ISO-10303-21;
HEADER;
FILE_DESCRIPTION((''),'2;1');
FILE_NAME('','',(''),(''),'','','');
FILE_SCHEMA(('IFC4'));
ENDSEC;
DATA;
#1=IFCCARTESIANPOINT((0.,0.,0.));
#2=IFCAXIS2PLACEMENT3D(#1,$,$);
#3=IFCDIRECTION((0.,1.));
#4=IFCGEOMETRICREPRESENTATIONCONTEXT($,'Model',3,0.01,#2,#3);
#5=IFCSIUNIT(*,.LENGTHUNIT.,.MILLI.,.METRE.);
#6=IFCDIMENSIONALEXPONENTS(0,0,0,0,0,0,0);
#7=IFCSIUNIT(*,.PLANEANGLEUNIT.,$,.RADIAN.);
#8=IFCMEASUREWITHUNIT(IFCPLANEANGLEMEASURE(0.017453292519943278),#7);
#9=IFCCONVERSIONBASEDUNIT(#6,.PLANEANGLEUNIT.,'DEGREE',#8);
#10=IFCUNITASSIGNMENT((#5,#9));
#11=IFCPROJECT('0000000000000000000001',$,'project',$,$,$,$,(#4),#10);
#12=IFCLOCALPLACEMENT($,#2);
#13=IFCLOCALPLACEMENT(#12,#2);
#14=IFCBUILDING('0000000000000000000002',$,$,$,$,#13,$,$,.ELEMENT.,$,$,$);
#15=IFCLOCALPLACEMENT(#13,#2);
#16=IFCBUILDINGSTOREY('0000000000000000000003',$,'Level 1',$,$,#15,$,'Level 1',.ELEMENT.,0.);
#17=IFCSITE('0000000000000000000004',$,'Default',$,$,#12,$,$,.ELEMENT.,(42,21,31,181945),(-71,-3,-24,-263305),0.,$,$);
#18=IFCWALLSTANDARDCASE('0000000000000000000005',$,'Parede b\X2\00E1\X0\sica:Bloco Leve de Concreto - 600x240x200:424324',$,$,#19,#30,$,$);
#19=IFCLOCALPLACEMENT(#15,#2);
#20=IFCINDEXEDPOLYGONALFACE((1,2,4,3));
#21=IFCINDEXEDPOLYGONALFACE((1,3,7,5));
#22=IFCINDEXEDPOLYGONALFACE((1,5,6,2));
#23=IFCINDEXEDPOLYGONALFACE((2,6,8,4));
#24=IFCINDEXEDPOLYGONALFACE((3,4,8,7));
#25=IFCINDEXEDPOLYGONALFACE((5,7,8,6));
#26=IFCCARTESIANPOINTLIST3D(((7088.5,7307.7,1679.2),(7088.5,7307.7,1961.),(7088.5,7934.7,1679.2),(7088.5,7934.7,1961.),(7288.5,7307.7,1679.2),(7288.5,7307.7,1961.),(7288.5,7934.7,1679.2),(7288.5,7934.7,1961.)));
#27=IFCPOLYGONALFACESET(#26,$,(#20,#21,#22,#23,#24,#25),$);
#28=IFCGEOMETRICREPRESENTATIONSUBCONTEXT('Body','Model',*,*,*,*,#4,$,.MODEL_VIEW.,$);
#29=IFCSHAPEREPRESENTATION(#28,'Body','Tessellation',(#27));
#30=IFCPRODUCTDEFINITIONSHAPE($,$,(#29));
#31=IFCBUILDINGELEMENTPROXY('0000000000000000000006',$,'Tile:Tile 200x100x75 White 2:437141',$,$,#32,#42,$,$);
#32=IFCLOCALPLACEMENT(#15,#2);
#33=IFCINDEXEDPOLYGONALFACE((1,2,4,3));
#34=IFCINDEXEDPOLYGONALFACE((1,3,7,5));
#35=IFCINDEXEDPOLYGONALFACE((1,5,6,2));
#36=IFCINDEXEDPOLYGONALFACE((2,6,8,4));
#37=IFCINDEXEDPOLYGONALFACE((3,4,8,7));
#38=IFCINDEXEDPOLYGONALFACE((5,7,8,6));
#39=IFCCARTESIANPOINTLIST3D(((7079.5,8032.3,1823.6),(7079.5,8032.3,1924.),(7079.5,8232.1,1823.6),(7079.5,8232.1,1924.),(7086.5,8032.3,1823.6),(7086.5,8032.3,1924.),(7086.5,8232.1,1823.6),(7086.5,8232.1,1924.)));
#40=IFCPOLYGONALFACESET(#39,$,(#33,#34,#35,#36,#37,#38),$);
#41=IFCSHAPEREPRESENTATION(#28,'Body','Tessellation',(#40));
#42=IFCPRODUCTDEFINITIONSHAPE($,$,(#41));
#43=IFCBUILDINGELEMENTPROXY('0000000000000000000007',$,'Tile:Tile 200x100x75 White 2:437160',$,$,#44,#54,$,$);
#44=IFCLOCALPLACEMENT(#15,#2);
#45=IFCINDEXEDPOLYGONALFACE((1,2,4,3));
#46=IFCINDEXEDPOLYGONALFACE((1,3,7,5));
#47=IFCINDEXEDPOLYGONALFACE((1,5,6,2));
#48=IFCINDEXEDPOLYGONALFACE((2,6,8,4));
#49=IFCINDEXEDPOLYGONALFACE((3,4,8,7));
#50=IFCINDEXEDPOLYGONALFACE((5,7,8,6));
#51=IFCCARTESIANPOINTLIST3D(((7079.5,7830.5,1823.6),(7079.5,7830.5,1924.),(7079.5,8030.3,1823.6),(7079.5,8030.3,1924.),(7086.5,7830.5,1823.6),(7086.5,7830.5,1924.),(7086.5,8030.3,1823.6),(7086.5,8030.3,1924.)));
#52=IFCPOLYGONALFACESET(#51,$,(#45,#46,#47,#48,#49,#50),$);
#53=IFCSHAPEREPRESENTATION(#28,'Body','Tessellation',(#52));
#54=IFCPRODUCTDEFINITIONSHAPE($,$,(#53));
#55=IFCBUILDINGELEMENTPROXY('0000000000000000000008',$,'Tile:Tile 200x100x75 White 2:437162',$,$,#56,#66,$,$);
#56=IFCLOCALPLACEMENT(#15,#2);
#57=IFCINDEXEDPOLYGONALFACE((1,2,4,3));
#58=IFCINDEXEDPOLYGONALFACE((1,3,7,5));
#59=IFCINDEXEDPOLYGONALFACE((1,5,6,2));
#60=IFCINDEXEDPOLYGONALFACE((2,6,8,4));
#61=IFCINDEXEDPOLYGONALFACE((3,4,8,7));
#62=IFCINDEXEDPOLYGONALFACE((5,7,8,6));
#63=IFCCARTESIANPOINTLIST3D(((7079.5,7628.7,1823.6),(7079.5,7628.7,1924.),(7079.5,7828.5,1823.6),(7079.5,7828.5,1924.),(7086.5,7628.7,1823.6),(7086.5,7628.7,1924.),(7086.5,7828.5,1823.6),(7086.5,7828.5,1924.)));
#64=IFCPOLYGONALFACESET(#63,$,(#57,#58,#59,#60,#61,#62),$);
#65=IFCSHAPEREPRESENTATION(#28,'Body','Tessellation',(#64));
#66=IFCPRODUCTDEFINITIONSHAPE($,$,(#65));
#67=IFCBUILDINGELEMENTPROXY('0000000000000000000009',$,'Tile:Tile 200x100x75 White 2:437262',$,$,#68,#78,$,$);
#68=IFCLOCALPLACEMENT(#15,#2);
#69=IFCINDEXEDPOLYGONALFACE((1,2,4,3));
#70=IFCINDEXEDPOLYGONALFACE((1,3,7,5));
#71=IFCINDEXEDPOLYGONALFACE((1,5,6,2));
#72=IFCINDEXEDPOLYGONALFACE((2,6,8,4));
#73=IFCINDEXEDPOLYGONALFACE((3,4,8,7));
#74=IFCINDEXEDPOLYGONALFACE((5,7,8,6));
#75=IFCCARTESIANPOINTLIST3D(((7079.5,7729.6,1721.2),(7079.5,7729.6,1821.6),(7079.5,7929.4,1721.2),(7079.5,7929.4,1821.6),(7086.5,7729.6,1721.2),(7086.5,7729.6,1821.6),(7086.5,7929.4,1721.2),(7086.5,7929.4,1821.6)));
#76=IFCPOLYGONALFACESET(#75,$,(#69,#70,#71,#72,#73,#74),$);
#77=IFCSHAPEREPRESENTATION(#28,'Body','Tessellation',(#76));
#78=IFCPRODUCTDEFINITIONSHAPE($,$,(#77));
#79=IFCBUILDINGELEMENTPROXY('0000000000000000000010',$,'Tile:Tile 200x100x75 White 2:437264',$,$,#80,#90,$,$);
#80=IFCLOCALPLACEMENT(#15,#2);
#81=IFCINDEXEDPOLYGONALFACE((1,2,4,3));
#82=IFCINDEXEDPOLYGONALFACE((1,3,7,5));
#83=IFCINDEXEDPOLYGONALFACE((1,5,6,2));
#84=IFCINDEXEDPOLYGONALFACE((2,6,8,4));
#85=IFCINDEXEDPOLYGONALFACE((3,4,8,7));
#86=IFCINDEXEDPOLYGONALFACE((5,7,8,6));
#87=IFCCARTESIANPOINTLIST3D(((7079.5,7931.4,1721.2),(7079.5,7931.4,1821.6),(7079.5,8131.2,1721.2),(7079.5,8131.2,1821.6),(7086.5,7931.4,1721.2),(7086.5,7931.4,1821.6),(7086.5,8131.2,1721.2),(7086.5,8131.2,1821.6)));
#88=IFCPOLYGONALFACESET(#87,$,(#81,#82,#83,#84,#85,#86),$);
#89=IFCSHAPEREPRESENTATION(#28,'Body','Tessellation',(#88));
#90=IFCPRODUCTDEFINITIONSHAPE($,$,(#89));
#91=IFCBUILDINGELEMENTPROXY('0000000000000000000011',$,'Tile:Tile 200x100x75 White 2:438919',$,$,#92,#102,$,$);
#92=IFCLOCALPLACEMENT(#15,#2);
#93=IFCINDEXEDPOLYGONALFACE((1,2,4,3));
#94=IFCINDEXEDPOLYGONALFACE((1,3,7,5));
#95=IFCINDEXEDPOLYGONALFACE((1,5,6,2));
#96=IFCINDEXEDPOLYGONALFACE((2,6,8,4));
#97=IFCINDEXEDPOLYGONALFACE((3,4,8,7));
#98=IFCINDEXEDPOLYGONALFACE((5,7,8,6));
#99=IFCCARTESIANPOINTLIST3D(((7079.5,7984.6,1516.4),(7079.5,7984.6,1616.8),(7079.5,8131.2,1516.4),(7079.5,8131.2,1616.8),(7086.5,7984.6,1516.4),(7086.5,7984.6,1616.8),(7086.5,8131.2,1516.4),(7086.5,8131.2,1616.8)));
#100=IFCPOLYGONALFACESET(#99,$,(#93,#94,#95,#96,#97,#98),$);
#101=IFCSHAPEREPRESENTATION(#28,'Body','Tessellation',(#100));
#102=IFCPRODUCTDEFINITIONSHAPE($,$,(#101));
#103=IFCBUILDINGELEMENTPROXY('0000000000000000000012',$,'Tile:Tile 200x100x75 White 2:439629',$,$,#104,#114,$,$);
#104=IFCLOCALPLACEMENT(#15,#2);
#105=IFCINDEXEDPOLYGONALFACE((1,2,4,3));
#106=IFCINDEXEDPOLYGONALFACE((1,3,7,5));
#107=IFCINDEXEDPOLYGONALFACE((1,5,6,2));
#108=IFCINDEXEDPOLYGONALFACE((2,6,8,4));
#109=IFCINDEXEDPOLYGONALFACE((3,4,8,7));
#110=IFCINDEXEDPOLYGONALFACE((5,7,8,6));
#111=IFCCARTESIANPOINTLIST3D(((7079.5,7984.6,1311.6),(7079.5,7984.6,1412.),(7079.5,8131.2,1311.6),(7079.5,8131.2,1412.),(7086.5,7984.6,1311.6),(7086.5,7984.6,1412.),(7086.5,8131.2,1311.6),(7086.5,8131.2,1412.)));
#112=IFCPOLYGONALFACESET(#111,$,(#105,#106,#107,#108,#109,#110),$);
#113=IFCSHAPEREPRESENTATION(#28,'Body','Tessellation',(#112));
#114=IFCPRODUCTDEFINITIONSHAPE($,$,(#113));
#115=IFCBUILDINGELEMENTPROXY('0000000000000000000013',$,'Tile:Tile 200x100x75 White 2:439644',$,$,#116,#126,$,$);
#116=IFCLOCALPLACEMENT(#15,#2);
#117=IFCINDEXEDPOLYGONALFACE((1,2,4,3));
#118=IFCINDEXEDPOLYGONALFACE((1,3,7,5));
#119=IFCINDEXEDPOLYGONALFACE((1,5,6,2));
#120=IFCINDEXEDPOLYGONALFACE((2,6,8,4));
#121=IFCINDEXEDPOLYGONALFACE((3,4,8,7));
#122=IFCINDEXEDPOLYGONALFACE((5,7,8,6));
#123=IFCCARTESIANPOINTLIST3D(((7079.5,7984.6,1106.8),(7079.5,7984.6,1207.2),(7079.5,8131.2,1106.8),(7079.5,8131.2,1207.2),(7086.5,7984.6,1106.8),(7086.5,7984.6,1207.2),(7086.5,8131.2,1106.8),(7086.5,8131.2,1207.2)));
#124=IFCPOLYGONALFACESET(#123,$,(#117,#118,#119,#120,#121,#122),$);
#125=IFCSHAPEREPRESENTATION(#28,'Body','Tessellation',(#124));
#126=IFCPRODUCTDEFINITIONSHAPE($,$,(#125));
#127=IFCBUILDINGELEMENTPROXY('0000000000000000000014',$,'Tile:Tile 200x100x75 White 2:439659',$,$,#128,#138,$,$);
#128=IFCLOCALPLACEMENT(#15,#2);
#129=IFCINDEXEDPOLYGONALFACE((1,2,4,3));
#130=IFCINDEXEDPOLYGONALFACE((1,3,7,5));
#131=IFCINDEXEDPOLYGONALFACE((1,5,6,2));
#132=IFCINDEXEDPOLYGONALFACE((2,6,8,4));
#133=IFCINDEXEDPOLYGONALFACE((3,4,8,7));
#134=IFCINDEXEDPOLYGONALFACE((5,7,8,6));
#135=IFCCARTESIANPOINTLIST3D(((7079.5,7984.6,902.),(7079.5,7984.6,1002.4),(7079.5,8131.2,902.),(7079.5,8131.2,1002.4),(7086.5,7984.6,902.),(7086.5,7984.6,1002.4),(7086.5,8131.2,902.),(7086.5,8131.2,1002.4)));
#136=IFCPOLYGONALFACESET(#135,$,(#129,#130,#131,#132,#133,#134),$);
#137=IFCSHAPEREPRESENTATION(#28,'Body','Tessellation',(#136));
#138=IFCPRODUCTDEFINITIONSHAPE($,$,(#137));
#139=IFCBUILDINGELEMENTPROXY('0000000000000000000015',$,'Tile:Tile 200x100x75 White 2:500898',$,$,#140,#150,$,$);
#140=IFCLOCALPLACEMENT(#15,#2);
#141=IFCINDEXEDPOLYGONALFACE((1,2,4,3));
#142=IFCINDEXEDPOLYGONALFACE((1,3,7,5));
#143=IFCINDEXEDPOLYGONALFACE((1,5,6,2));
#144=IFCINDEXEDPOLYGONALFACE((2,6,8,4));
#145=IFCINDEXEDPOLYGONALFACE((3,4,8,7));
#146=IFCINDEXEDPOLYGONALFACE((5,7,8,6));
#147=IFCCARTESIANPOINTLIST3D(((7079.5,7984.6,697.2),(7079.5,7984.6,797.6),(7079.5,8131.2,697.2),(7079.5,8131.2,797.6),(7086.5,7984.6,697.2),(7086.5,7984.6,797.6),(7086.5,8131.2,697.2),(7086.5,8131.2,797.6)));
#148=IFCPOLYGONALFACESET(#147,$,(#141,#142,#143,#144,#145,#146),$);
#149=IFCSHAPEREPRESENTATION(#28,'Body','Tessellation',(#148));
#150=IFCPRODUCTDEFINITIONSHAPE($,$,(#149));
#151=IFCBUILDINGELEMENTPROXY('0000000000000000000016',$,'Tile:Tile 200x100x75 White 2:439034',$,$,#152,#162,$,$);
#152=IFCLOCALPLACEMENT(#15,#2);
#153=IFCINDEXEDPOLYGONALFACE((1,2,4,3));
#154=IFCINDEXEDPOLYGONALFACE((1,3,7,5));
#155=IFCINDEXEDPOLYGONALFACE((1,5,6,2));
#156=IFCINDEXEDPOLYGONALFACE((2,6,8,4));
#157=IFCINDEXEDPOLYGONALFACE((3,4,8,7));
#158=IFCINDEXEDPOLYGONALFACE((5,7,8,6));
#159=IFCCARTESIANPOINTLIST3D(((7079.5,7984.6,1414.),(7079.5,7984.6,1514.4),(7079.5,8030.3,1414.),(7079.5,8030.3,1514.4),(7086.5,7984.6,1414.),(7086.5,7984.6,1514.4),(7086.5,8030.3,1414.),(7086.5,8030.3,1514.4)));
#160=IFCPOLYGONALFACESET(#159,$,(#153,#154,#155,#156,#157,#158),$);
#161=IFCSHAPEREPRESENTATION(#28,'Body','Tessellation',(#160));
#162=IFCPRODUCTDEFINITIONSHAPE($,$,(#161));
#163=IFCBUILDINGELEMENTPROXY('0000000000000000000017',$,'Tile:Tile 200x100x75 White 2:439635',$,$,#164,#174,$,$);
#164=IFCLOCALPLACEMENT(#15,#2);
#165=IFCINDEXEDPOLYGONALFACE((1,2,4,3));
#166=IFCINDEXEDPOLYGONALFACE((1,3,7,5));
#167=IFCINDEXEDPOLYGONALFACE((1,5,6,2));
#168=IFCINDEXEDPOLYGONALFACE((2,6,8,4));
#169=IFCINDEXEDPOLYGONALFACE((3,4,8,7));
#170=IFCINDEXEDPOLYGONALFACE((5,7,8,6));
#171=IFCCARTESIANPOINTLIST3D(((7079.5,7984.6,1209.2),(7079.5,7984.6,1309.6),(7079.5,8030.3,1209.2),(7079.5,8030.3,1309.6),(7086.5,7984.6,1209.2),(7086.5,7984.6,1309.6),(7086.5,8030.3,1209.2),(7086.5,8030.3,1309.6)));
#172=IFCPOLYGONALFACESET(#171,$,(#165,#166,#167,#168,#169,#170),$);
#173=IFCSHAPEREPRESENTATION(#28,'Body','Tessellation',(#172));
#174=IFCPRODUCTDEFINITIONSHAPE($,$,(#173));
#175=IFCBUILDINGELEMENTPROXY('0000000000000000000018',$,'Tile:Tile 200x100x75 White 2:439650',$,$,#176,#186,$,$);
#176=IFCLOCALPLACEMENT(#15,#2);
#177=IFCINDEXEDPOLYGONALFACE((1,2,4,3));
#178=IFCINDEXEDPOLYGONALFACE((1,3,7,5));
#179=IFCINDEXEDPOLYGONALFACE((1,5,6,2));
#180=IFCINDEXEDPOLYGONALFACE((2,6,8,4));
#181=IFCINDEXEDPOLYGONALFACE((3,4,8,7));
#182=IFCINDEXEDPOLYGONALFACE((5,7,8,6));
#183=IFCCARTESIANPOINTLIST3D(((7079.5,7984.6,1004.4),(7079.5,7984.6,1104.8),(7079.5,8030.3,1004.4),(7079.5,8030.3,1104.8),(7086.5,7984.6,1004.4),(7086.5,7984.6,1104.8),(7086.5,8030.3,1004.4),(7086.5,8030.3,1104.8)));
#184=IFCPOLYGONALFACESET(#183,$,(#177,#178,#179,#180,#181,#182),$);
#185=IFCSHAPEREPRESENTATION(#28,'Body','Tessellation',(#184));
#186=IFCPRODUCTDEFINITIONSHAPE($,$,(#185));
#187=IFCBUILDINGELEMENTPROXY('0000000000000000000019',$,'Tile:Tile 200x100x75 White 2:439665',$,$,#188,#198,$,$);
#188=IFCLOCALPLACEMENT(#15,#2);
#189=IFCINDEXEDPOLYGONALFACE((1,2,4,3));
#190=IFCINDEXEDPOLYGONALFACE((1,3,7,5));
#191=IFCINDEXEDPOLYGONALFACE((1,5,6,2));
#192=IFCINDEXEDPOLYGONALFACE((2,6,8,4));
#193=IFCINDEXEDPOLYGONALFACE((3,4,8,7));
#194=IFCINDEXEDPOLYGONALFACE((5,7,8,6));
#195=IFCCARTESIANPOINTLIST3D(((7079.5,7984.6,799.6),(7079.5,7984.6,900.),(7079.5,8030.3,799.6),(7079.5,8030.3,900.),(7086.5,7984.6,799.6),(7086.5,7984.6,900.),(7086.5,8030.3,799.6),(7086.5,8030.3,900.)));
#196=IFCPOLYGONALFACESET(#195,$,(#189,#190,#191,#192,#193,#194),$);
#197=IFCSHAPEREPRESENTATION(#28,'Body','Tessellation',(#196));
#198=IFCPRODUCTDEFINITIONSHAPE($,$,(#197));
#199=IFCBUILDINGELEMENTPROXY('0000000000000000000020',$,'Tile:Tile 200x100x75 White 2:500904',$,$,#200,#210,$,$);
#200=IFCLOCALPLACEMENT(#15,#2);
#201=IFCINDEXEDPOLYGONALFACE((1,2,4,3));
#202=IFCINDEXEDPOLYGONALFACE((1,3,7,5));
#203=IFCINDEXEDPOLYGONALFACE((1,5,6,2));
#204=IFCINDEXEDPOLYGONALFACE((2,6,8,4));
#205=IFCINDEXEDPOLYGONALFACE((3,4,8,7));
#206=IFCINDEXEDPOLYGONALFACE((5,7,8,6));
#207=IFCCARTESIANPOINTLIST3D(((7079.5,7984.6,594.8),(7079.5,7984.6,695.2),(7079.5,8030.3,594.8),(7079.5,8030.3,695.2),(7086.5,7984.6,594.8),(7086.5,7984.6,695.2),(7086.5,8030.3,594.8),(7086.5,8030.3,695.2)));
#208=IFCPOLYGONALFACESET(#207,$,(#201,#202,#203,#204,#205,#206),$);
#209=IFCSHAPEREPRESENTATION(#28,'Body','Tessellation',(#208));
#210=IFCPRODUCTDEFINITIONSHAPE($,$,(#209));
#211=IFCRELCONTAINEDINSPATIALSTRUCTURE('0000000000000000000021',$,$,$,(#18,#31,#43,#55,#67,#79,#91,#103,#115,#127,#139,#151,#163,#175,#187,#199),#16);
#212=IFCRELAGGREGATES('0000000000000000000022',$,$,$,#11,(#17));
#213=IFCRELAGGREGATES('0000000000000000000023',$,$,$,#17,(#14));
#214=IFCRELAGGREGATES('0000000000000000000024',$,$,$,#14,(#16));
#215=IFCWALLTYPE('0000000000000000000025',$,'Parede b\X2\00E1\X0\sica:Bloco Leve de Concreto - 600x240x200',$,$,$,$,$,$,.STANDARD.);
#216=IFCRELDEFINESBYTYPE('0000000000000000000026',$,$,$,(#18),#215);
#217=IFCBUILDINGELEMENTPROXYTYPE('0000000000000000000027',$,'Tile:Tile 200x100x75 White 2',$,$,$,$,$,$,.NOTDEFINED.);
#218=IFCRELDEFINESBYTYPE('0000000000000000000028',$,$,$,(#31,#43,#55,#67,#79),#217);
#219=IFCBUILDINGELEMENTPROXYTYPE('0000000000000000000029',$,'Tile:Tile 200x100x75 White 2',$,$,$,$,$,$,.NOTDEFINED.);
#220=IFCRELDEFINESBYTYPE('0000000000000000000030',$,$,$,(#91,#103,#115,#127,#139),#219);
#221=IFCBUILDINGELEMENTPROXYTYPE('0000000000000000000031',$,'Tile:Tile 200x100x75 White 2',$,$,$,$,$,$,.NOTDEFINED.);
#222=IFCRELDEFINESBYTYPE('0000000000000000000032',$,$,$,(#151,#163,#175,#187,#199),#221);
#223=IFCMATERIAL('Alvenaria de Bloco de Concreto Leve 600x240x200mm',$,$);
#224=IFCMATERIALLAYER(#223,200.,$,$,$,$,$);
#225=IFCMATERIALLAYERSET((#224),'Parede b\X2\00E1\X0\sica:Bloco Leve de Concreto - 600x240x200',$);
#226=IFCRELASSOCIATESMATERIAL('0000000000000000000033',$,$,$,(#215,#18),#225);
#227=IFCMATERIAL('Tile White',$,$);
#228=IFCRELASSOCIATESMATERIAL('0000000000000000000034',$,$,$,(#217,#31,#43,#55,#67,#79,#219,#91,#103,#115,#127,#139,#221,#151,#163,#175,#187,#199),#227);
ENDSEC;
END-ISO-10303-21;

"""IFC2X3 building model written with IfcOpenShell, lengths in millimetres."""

from ifc_helpers import new_model, entity, si_unit, converted_unit, direction, frame, frame_2d, origin, origin_2d_with_axis, place, context, subcontext, project, spatial, rectangle, extrude, source, transform, mapped, material, layer, layer_set, layer_usage, type_object, type_shapes, element, save


model = new_model("IFC2X3")

# Units and contexts
model_context = context("Model", 3, precision=0.01, world=origin(), true_north=direction((0.0, 1.0)))
body_context = subcontext(model_context, "Body", "Model", "MODEL_VIEW")
ifc_project = project(units=[si_unit("LENGTHUNIT", "METRE", prefix="MILLI"), converted_unit("PLANEANGLEUNIT", "DEGREE", entity("IfcPlaneAngleMeasure", 0.017453292519943278), si_unit("PLANEANGLEUNIT", "RADIAN"), dimensions=[0, 0, 0, 0, 0, 0, 0])], contexts=[model_context])

# Site, building, storey
site_placement = place(None, origin())
site = spatial("IfcSite", under=ifc_project, at=site_placement, Name="Default", CompositionType="ELEMENT", RefLatitude=(42, 21, 31, 181945), RefLongitude=(-71, -3, -24, -263305), RefElevation=0.0)
building_placement = place(site_placement, origin())
building = spatial("IfcBuilding", under=site, at=building_placement, CompositionType="ELEMENT")
storey_placement = place(building_placement, origin())
storey = spatial("IfcBuildingStorey", under=building, at=storey_placement, Name="Level 1", LongName="Level 1", CompositionType="ELEMENT", Elevation=0.0)

# Wall
ifc_material_1 = material(Name="Alvenaria de Bloco de Concreto Leve 600x240x200mm")
ifc_layer = layer(ifc_material_1, 200.0)
ifc_layer_set = layer_set([ifc_layer], Name="Parede básica:Bloco Leve de Concreto - 600x240x200")
ifc_layer_usage = layer_usage(ifc_layer_set, "AXIS2", "NEGATIVE", 100.0)
wall_type = type_object("IfcWallType", Name="Parede básica:Bloco Leve de Concreto - 600x240x200", PredefinedType="STANDARD", material=ifc_layer_set)
wall_placement = place(storey_placement, frame((7188.5, 7934.7, 1679.2), z_axis=(0.0, 0.0, 1.0), x_axis=(0.0, -1.0, 0.0)))
element("IfcWallStandardCase", 1, at=wall_placement, inside=storey, type_object=wall_type, material=ifc_layer_usage, Name="Parede básica:Bloco Leve de Concreto - 600x240x200:424324", context=body_context, shape_type="SweptSolid", body=[
    extrude(rectangle(XDim=627.0, YDim=200.0, at=frame_2d((313.5, 0.0), x_axis=(-1.0, 0.0))), origin(), (0.0, 0.0, 1.0), 281.8),
])

# Building element proxies
ifc_material_2 = material(Name="Tile White")
building_element_proxy_type_1 = type_object("IfcBuildingElementProxyType", Name="Tile:Tile 200x100x75 White 2", PredefinedType="NOTDEFINED", material=ifc_material_2)
shared_shape_1 = source(origin(), body_context, "Body", "SweptSolid", [
    extrude(rectangle(XDim=199.8, YDim=100.4, at=frame_2d((0.0, 0.0), x_axis=(1.0, 0.0))), frame((-50.2, -99.9, 0.0), z_axis=(0.0, 0.0, 1.0), x_axis=(0.0, -1.0, 0.0)), (0.0, 0.0, 1.0), 7.0),
])
type_shapes(building_element_proxy_type_1, [shared_shape_1])
for number, where, z_axis, x_axis, name in (
    (2, (7086.5, 8232.1, 1924.0), (-1.0, 0.0, 0.0), (0.0, 0.0, 1.0), "Tile:Tile 200x100x75 White 2:437141"),
    (3, (7086.5, 8030.3, 1924.0), (-1.0, 0.0, 0.0), (0.0, 0.0, 1.0), "Tile:Tile 200x100x75 White 2:437160"),
    (4, (7086.5, 7828.5, 1924.0), (-1.0, 0.0, 0.0), (0.0, 0.0, 1.0), "Tile:Tile 200x100x75 White 2:437162"),
    (5, (7086.5, 7929.4, 1821.6), (-1.0, 0.0, 0.0), (0.0, 0.0, 1.0), "Tile:Tile 200x100x75 White 2:437262"),
    (6, (7086.5, 8131.2, 1821.6), (-1.0, 0.0, 0.0), (0.0, 0.0, 1.0), "Tile:Tile 200x100x75 White 2:437264"),
):
    element("IfcBuildingElementProxy", number, at=place(storey_placement, frame(where, z_axis=z_axis, x_axis=x_axis)), inside=storey, type_object=building_element_proxy_type_1, material=ifc_material_2, Name=name, context=body_context, shape_type="MappedRepresentation", body=[
        mapped(shared_shape_1, transform((0.0, 0.0, 0.0), scale=1.0)),
    ])
building_element_proxy_type_2 = type_object("IfcBuildingElementProxyType", Name="Tile:Tile 200x100x75 White 2", PredefinedType="NOTDEFINED", material=ifc_material_2)
shared_shape_2 = source(origin(), body_context, "Body", "SweptSolid", [
    extrude(rectangle(XDim=146.6, YDim=100.4, at=origin_2d_with_axis()), frame((-50.2, -73.3, 0.0), z_axis=(0.0, 0.0, 1.0), x_axis=(0.0, -1.0, 0.0)), (0.0, 0.0, 1.0), 7.0),
])
type_shapes(building_element_proxy_type_2, [shared_shape_2])
for number, where, z_axis, x_axis, name in (
    (7, (7086.5, 8131.2, 1616.8), (-1.0, 0.0, 0.0), (0.0, 0.0, 1.0), "Tile:Tile 200x100x75 White 2:438919"),
    (8, (7086.5, 8131.2, 1412.0), (-1.0, 0.0, 0.0), (0.0, 0.0, 1.0), "Tile:Tile 200x100x75 White 2:439629"),
    (9, (7086.5, 8131.2, 1207.2), (-1.0, 0.0, 0.0), (0.0, 0.0, 1.0), "Tile:Tile 200x100x75 White 2:439644"),
    (10, (7086.5, 8131.2, 1002.4), (-1.0, 0.0, 0.0), (0.0, 0.0, 1.0), "Tile:Tile 200x100x75 White 2:439659"),
    (11, (7086.5, 8131.2, 797.6), (-1.0, 0.0, 0.0), (0.0, 0.0, 1.0), "Tile:Tile 200x100x75 White 2:500898"),
):
    element("IfcBuildingElementProxy", number, at=place(storey_placement, frame(where, z_axis=z_axis, x_axis=x_axis)), inside=storey, type_object=building_element_proxy_type_2, material=ifc_material_2, Name=name, context=body_context, shape_type="MappedRepresentation", body=[
        mapped(shared_shape_2, transform((0.0, 0.0, 0.0), scale=1.0)),
    ])
building_element_proxy_type_3 = type_object("IfcBuildingElementProxyType", Name="Tile:Tile 200x100x75 White 2", PredefinedType="NOTDEFINED", material=ifc_material_2)
shared_shape_3 = source(origin(), body_context, "Body", "SweptSolid", [
    extrude(rectangle(XDim=45.7, YDim=100.4, at=frame_2d((0.0, 0.0), x_axis=(1.0, 0.0))), frame((-50.2, -22.9, 0.0), z_axis=(0.0, 0.0, 1.0), x_axis=(0.0, -1.0, 0.0)), (0.0, 0.0, 1.0), 7.0),
])
type_shapes(building_element_proxy_type_3, [shared_shape_3])
for number, where, z_axis, x_axis, name in (
    (12, (7086.5, 8030.3, 1514.4), (-1.0, 0.0, 0.0), (0.0, 0.0, 1.0), "Tile:Tile 200x100x75 White 2:439034"),
    (13, (7086.5, 8030.3, 1309.6), (-1.0, 0.0, 0.0), (0.0, 0.0, 1.0), "Tile:Tile 200x100x75 White 2:439635"),
    (14, (7086.5, 8030.3, 1104.8), (-1.0, 0.0, 0.0), (0.0, 0.0, 1.0), "Tile:Tile 200x100x75 White 2:439650"),
    (15, (7086.5, 8030.3, 900.0), (-1.0, 0.0, 0.0), (0.0, 0.0, 1.0), "Tile:Tile 200x100x75 White 2:439665"),
    (16, (7086.5, 8030.3, 695.2), (-1.0, 0.0, 0.0), (0.0, 0.0, 1.0), "Tile:Tile 200x100x75 White 2:500904"),
):
    element("IfcBuildingElementProxy", number, at=place(storey_placement, frame(where, z_axis=z_axis, x_axis=x_axis)), inside=storey, type_object=building_element_proxy_type_3, material=ifc_material_2, Name=name, context=body_context, shape_type="MappedRepresentation", body=[
        mapped(shared_shape_3, transform((0.0, 0.0, 0.0), scale=1.0)),
    ])

save(model, "model.ifc")
